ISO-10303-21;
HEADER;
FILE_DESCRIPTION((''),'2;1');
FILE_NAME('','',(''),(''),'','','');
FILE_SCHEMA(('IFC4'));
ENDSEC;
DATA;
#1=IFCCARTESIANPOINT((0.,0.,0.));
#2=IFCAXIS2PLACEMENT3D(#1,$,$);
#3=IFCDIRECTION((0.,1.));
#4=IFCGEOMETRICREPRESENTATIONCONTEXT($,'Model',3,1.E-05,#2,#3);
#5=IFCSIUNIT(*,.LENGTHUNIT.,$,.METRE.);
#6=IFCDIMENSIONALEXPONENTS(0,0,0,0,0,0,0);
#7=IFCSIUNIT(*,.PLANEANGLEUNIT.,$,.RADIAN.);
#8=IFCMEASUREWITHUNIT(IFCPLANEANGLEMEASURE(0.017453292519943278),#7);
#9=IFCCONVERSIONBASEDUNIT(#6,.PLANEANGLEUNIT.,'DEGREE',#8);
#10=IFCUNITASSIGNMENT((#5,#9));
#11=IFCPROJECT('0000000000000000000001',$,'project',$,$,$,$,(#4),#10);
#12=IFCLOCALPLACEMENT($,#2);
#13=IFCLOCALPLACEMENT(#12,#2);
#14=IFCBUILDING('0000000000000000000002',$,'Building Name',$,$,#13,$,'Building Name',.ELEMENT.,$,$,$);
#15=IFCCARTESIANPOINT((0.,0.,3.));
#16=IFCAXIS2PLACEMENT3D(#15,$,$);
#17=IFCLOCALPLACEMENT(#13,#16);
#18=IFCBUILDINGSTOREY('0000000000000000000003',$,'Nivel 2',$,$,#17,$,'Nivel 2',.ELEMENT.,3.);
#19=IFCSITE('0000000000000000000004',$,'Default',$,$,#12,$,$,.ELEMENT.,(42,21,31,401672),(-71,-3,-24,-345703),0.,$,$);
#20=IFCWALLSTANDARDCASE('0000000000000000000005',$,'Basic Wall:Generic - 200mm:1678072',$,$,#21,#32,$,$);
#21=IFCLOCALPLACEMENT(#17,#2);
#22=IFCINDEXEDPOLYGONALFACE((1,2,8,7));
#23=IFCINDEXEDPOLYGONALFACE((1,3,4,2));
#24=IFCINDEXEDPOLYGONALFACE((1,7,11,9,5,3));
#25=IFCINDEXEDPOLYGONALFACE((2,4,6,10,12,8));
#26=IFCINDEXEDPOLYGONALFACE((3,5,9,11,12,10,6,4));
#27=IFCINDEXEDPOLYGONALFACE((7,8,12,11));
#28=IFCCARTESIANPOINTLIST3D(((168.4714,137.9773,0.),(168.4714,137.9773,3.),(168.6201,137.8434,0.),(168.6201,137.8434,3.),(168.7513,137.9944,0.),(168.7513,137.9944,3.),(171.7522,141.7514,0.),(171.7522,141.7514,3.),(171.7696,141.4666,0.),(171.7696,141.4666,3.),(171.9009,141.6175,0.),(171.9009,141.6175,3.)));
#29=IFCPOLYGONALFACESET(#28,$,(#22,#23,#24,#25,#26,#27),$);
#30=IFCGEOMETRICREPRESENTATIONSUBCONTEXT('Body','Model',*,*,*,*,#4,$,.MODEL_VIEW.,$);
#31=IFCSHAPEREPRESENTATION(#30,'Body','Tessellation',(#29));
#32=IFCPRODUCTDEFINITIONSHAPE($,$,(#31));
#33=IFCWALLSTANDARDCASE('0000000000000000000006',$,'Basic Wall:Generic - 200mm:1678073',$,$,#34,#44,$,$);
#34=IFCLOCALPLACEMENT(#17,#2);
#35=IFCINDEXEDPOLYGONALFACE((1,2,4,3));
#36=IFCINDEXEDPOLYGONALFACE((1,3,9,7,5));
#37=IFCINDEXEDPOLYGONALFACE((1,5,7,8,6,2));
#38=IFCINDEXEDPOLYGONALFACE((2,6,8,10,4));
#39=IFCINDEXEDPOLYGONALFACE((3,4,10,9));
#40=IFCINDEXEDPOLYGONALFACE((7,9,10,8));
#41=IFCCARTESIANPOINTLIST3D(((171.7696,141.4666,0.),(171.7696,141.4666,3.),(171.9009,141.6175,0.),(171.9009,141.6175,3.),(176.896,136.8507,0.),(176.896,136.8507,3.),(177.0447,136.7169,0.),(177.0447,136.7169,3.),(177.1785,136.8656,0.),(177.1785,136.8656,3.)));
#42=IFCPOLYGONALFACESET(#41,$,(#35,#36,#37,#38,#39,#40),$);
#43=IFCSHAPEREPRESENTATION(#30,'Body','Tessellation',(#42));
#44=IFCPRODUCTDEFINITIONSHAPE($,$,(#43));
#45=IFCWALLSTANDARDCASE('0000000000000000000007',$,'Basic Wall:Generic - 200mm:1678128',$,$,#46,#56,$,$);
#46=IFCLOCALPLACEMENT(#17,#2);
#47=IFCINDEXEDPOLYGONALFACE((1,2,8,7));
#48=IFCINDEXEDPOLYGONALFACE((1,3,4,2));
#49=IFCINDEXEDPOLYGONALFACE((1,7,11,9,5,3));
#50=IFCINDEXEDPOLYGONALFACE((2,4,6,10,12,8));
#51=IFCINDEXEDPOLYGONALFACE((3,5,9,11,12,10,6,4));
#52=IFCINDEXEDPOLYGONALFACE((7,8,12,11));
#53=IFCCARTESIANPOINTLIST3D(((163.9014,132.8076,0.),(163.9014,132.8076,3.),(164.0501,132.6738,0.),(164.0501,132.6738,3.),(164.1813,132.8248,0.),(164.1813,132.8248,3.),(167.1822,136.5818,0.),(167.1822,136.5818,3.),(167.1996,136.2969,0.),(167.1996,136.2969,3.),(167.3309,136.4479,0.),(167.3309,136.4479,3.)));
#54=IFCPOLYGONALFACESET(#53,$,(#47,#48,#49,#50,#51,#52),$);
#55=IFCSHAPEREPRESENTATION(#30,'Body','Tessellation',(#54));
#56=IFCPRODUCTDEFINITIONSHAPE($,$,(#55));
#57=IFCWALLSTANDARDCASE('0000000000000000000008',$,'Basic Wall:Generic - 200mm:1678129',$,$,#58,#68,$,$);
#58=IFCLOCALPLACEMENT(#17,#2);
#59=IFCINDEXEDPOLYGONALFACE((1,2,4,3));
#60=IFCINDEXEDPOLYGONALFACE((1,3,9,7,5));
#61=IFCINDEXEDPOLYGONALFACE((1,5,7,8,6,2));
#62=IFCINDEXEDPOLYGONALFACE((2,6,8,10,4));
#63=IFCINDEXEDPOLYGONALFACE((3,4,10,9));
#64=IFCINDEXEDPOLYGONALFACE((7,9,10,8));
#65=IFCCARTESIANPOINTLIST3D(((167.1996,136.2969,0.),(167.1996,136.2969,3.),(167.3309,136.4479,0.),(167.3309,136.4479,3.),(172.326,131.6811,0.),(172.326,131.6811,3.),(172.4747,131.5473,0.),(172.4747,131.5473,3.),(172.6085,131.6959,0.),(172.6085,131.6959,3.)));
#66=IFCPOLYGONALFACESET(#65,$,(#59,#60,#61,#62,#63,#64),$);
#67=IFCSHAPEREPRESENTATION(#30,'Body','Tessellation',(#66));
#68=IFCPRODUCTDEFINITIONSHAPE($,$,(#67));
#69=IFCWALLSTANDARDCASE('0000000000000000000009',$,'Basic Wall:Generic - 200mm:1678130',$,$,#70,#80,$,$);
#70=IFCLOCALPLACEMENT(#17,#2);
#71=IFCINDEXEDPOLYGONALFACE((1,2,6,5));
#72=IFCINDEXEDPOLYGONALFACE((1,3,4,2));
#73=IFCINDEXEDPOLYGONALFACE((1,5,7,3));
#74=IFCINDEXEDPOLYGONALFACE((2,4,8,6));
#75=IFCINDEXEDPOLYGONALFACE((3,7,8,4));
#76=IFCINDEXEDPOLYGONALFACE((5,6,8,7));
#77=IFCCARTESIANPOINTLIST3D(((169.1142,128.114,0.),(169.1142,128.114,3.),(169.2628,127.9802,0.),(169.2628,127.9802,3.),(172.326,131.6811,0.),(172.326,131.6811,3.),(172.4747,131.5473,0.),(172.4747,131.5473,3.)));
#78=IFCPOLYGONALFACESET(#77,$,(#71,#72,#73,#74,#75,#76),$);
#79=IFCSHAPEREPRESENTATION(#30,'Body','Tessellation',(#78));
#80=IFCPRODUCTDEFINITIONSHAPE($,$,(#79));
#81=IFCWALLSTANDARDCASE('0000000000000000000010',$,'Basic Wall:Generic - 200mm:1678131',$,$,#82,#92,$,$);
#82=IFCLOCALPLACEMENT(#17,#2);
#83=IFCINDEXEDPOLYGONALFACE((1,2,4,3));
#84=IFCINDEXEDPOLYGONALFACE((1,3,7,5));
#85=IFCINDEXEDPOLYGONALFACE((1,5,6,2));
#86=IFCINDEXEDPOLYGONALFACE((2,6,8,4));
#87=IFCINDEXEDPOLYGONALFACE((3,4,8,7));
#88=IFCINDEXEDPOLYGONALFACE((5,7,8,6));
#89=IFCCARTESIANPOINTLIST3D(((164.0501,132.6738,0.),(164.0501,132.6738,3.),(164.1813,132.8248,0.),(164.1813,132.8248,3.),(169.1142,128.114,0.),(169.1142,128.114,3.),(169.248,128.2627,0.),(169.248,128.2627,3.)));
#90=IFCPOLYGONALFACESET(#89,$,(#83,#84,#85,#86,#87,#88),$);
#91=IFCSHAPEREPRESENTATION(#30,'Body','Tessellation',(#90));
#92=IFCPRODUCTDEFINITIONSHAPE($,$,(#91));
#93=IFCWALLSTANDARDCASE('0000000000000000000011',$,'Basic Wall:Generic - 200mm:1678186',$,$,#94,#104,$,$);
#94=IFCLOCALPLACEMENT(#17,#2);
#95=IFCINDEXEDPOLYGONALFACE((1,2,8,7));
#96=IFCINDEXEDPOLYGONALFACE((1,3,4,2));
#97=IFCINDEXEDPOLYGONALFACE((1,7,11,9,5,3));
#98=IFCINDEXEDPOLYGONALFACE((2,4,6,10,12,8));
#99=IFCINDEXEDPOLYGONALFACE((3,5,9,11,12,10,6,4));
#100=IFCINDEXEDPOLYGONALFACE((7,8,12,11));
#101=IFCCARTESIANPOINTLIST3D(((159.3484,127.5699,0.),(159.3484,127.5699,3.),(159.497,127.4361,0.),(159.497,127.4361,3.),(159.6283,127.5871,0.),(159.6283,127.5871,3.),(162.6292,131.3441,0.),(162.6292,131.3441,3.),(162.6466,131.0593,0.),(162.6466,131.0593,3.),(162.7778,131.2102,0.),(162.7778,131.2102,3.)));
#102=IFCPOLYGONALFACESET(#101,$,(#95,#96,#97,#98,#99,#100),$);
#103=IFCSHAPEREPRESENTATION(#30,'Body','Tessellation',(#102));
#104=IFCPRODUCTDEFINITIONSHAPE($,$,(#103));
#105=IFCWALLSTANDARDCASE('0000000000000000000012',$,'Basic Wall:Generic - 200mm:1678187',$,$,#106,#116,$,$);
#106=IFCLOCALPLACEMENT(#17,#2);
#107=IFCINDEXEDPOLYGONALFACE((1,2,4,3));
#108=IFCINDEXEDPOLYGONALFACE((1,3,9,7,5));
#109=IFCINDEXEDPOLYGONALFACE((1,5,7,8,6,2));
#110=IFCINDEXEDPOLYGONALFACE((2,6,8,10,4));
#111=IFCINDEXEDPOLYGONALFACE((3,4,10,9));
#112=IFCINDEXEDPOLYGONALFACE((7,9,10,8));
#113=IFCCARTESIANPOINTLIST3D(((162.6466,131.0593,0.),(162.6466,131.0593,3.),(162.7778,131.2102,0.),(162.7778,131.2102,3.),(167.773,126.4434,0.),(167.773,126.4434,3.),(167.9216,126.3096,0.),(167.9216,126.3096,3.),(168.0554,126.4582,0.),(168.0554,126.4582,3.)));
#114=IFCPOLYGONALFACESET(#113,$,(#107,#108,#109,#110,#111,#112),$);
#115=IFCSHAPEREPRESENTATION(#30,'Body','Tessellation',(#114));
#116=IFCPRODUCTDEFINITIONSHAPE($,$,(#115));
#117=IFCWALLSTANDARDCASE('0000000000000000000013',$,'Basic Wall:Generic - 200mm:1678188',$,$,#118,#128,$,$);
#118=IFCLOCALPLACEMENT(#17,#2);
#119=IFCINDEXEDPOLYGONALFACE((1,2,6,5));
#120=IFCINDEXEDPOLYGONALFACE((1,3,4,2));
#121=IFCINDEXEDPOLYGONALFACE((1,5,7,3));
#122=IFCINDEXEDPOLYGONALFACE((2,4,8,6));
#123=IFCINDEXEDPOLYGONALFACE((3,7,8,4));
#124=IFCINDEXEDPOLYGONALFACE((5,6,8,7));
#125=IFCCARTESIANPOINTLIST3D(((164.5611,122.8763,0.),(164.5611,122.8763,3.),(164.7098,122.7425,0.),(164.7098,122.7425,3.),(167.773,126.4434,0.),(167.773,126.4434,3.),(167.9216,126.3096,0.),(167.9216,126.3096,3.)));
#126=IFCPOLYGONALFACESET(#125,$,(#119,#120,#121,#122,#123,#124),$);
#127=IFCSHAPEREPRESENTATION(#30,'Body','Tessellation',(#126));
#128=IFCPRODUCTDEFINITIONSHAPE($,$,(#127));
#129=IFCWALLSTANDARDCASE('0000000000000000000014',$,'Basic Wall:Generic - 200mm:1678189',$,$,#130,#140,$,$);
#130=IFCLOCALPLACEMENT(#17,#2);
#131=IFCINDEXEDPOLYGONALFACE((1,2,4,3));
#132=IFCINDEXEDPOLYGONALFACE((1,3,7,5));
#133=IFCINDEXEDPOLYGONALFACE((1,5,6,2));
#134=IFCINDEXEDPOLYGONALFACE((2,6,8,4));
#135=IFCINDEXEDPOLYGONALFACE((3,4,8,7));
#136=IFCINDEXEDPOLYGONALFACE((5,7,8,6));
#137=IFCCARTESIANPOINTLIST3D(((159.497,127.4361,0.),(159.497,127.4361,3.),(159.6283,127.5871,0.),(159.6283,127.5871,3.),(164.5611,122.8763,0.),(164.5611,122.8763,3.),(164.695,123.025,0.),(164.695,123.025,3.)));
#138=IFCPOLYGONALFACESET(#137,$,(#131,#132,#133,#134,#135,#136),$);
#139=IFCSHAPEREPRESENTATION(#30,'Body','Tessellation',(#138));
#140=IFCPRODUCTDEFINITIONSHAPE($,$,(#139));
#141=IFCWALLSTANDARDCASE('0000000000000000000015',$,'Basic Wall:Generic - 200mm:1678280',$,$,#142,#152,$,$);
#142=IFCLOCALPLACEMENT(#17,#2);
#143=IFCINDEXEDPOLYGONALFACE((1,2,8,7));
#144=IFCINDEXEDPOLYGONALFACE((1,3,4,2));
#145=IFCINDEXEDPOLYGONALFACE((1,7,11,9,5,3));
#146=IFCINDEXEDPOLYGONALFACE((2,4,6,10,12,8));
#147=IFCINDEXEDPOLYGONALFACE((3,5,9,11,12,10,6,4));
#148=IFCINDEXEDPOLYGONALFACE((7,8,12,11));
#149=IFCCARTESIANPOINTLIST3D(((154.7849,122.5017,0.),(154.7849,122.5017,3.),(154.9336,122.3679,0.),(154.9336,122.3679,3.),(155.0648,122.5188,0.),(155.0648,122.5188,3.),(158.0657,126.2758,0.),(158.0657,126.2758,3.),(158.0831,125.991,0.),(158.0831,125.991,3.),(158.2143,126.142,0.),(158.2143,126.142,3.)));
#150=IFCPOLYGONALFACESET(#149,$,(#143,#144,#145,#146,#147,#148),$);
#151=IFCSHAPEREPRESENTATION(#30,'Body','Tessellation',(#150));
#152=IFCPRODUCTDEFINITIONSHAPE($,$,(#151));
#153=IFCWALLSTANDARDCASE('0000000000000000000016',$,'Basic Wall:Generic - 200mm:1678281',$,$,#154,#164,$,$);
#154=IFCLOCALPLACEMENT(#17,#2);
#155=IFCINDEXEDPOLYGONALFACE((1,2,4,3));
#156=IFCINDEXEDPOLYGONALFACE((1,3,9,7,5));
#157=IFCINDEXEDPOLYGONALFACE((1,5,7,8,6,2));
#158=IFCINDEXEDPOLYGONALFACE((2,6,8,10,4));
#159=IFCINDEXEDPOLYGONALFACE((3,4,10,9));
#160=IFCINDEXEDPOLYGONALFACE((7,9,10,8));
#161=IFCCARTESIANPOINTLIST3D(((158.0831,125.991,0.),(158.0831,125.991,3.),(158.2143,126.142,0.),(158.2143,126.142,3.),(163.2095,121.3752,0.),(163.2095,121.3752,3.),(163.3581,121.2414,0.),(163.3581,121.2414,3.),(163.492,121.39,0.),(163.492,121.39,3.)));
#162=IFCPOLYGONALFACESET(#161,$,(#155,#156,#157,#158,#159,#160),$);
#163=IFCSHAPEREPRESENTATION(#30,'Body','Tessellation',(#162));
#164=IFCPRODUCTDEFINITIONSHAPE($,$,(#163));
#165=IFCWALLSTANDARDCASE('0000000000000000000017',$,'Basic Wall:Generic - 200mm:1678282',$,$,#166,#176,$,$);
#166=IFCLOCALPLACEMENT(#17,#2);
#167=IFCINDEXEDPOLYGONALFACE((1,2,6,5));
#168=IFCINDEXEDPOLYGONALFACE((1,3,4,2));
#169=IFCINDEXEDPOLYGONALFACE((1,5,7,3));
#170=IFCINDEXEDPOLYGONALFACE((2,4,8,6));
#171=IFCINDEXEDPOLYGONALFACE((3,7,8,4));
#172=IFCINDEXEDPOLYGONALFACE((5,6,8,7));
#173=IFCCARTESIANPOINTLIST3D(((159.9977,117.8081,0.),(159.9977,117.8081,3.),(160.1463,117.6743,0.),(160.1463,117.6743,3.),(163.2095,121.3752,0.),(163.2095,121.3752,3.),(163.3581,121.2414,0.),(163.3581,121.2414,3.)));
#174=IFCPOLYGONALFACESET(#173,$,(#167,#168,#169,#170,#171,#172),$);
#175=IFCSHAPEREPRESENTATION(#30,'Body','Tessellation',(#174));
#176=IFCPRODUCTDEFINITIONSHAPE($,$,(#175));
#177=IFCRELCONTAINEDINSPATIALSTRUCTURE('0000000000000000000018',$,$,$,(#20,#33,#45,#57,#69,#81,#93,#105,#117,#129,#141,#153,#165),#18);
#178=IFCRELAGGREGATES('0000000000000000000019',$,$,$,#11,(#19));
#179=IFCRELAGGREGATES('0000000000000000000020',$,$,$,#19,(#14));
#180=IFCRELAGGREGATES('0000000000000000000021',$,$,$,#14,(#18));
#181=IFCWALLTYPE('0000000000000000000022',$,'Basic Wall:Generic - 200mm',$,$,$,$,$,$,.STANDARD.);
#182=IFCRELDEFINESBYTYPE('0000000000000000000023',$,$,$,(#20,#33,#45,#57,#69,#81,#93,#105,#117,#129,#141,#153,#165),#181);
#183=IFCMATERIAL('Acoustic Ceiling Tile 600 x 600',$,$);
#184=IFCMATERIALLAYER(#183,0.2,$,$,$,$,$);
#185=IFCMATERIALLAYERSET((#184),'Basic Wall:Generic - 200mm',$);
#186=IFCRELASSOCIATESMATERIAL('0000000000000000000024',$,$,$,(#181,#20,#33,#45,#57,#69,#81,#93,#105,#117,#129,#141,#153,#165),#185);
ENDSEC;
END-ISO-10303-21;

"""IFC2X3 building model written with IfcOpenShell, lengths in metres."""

from ifc_helpers import new_model, entity, si_unit, converted_unit, direction, frame, frame_2d, origin, place, context, subcontext, project, spatial, polyline, rectangle, outline, extrude, material, layer, layer_set, layer_usage, type_object, element, save


model = new_model("IFC2X3")

# Units and contexts
model_context = context("Model", 3, precision=1e-05, world=origin(), true_north=direction((0.0, 1.0)))
body_context = subcontext(model_context, "Body", "Model", "MODEL_VIEW")
ifc_project = project(units=[si_unit("LENGTHUNIT", "METRE"), converted_unit("PLANEANGLEUNIT", "DEGREE", entity("IfcPlaneAngleMeasure", 0.017453292519943278), si_unit("PLANEANGLEUNIT", "RADIAN"), dimensions=[0, 0, 0, 0, 0, 0, 0])], contexts=[model_context])

# Site, building, storey
site_placement = place(None, origin())
site = spatial("IfcSite", under=ifc_project, at=site_placement, Name="Default", CompositionType="ELEMENT", RefLatitude=(42, 21, 31, 401672), RefLongitude=(-71, -3, -24, -345703), RefElevation=0.0)
building_placement = place(site_placement, origin())
building = spatial("IfcBuilding", under=site, at=building_placement, Name="Building Name", LongName="Building Name", CompositionType="ELEMENT")
storey_placement = place(building_placement, frame((0.0, 0.0, 3.0)))
storey = spatial("IfcBuildingStorey", under=building, at=storey_placement, Name="Nivel 2", LongName="Nivel 2", CompositionType="ELEMENT", Elevation=3.0)

# Shared definitions
ifc_material_1 = material(Name="Acoustic Ceiling Tile 600 x 600")
ifc_layer = layer(ifc_material_1, 0.2)
ifc_layer_set = layer_set([ifc_layer], Name="Basic Wall:Generic - 200mm")
wall_type_1 = type_object("IfcWallType", Name="Basic Wall:Generic - 200mm", PredefinedType="STANDARD", material=ifc_layer_set)

# Walls
ifc_layer_usage_1 = layer_usage(ifc_layer_set, "AXIS2", "NEGATIVE", 0.1)
wall_1_placement = place(storey_placement, frame((168.5446, 137.909, 0.0), z_axis=(0.0, 0.0, 1.0), x_axis=(0.656059, 0.75471, 0.0)))
element("IfcWallStandardCase", 1, at=wall_1_placement, inside=storey, type_object=wall_type_1, material=ifc_layer_usage_1, Name="Basic Wall:Generic - 200mm:1678072", context=body_context, shape_type="SweptSolid", body=[
    extrude(outline(polyline([(5.0008, -0.1), (5.0043, 0.1), (0.0035, 0.1), (0.0, -0.1), (0.2, -0.1), (4.8007, -0.1), (5.0008, -0.1)])), origin(), (0.0, 0.0, 1.0), 3.0),
])
ifc_layer_usage_2 = layer_usage(ifc_layer_set, "AXIS2", "NEGATIVE", 0.1)
wall_2_placement = place(storey_placement, frame((171.834, 141.5432, 0.0), z_axis=(0.0, 0.0, 1.0), x_axis=(0.743145, -0.669131, 0.0)))
element("IfcWallStandardCase", 2, at=wall_2_placement, inside=storey, type_object=wall_type_1, material=ifc_layer_usage_2, Name="Basic Wall:Generic - 200mm:1678073", context=body_context, shape_type="SweptSolid", body=[
    extrude(outline(polyline([(7.1017, -0.1), (7.1017, 0.1), (0.0, 0.1), (0.0035, -0.1), (6.9017, -0.1), (7.1017, -0.1)])), origin(), (0.0, 0.0, 1.0), 3.0),
])
ifc_layer_usage_3 = layer_usage(ifc_layer_set, "AXIS2", "NEGATIVE", 0.1)
wall_3_placement = place(storey_placement, frame((163.9746, 132.7394, 0.0), z_axis=(0.0, 0.0, 1.0), x_axis=(0.656059, 0.75471, 0.0)))
element("IfcWallStandardCase", 3, at=wall_3_placement, inside=storey, type_object=wall_type_1, material=ifc_layer_usage_3, Name="Basic Wall:Generic - 200mm:1678128", context=body_context, shape_type="SweptSolid", body=[
    extrude(outline(polyline([(5.0008, -0.1), (5.0043, 0.1), (0.0035, 0.1), (0.0, -0.1), (0.2, -0.1), (4.8007, -0.1), (5.0008, -0.1)])), origin(), (0.0, 0.0, 1.0), 3.0),
])
ifc_layer_usage_4 = layer_usage(ifc_layer_set, "AXIS2", "NEGATIVE", 0.1)
wall_4_placement = place(storey_placement, frame((167.264, 136.3736, 0.0), z_axis=(0.0, 0.0, 1.0), x_axis=(0.743145, -0.669131, 0.0)))
element("IfcWallStandardCase", 4, at=wall_4_placement, inside=storey, type_object=wall_type_1, material=ifc_layer_usage_4, Name="Basic Wall:Generic - 200mm:1678129", context=body_context, shape_type="SweptSolid", body=[
    extrude(outline(polyline([(7.1017, -0.1), (7.1017, 0.1), (0.0, 0.1), (0.0035, -0.1), (6.9017, -0.1), (7.1017, -0.1)])), origin(), (0.0, 0.0, 1.0), 3.0),
])
ifc_layer_usage_5 = layer_usage(ifc_layer_set, "AXIS2", "NEGATIVE", 0.1)
wall_5_placement = place(storey_placement, frame((172.4003, 131.6142, 0.0), z_axis=(0.0, 0.0, 1.0), x_axis=(-0.669131, -0.743145, 0.0)))
element("IfcWallStandardCase", 5, at=wall_5_placement, inside=storey, type_object=wall_type_1, material=ifc_layer_usage_5, Name="Basic Wall:Generic - 200mm:1678130", context=body_context, shape_type="SweptSolid", body=[
    extrude(rectangle(XDim=4.8, YDim=0.2, at=frame_2d((2.4, 0.0), x_axis=(-1.0, 0.0))), origin(), (0.0, 0.0, 1.0), 3.0),
])
ifc_layer_usage_6 = layer_usage(ifc_layer_set, "AXIS2", "NEGATIVE", 0.1)
wall_6_placement = place(storey_placement, frame((169.1811, 128.1883, 0.0), z_axis=(0.0, 0.0, 1.0), x_axis=(-0.743145, 0.669131, 0.0)))
element("IfcWallStandardCase", 6, at=wall_6_placement, inside=storey, type_object=wall_type_1, material=ifc_layer_usage_6, Name="Basic Wall:Generic - 200mm:1678131", context=body_context, shape_type="SweptSolid", body=[
    extrude(outline(polyline([(6.8179, -0.1), (6.8145, 0.1), (0.0, 0.1), (0.0, -0.1), (6.8179, -0.1)])), origin(), (0.0, 0.0, 1.0), 3.0),
])
ifc_layer_usage_7 = layer_usage(ifc_layer_set, "AXIS2", "NEGATIVE", 0.1)
wall_7_placement = place(storey_placement, frame((159.4216, 127.5017, 0.0), z_axis=(0.0, 0.0, 1.0), x_axis=(0.656059, 0.75471, 0.0)))
element("IfcWallStandardCase", 7, at=wall_7_placement, inside=storey, type_object=wall_type_1, material=ifc_layer_usage_7, Name="Basic Wall:Generic - 200mm:1678186", context=body_context, shape_type="SweptSolid", body=[
    extrude(outline(polyline([(5.0008, -0.1), (5.0043, 0.1), (0.0035, 0.1), (0.0, -0.1), (0.2, -0.1), (4.8007, -0.1), (5.0008, -0.1)])), origin(), (0.0, 0.0, 1.0), 3.0),
])
ifc_layer_usage_8 = layer_usage(ifc_layer_set, "AXIS2", "NEGATIVE", 0.1)
wall_8_placement = place(storey_placement, frame((162.7109, 131.1359, 0.0), z_axis=(0.0, 0.0, 1.0), x_axis=(0.743145, -0.669131, 0.0)))
element("IfcWallStandardCase", 8, at=wall_8_placement, inside=storey, type_object=wall_type_1, material=ifc_layer_usage_8, Name="Basic Wall:Generic - 200mm:1678187", context=body_context, shape_type="SweptSolid", body=[
    extrude(outline(polyline([(7.1017, -0.1), (7.1017, 0.1), (0.0, 0.1), (0.0035, -0.1), (6.9017, -0.1), (7.1017, -0.1)])), origin(), (0.0, 0.0, 1.0), 3.0),
])
ifc_layer_usage_9 = layer_usage(ifc_layer_set, "AXIS2", "NEGATIVE", 0.1)
wall_9_placement = place(storey_placement, frame((167.8473, 126.3765, 0.0), z_axis=(0.0, 0.0, 1.0), x_axis=(-0.669131, -0.743145, 0.0)))
element("IfcWallStandardCase", 9, at=wall_9_placement, inside=storey, type_object=wall_type_1, material=ifc_layer_usage_9, Name="Basic Wall:Generic - 200mm:1678188", context=body_context, shape_type="SweptSolid", body=[
    extrude(rectangle(XDim=4.8, YDim=0.2, at=frame_2d((2.4, 0.0), x_axis=(-1.0, 0.0))), origin(), (0.0, 0.0, 1.0), 3.0),
])
ifc_layer_usage_10 = layer_usage(ifc_layer_set, "AXIS2", "NEGATIVE", 0.1)
wall_10_placement = place(storey_placement, frame((164.6281, 122.9507, 0.0), z_axis=(0.0, 0.0, 1.0), x_axis=(-0.743145, 0.669131, 0.0)))
element("IfcWallStandardCase", 10, at=wall_10_placement, inside=storey, type_object=wall_type_1, material=ifc_layer_usage_10, Name="Basic Wall:Generic - 200mm:1678189", context=body_context, shape_type="SweptSolid", body=[
    extrude(outline(polyline([(6.8179, -0.1), (6.8145, 0.1), (0.0, 0.1), (0.0, -0.1), (6.8179, -0.1)])), origin(), (0.0, 0.0, 1.0), 3.0),
])
ifc_layer_usage_11 = layer_usage(ifc_layer_set, "AXIS2", "NEGATIVE", 0.1)
wall_11_placement = place(storey_placement, frame((154.8581, 122.4335, 0.0), z_axis=(0.0, 0.0, 1.0), x_axis=(0.656059, 0.75471, 0.0)))
element("IfcWallStandardCase", 11, at=wall_11_placement, inside=storey, type_object=wall_type_1, material=ifc_layer_usage_11, Name="Basic Wall:Generic - 200mm:1678280", context=body_context, shape_type="SweptSolid", body=[
    extrude(outline(polyline([(5.0008, -0.1), (5.0043, 0.1), (0.0035, 0.1), (0.0, -0.1), (0.2, -0.1), (4.8007, -0.1), (5.0008, -0.1)])), origin(), (0.0, 0.0, 1.0), 3.0),
])
ifc_layer_usage_12 = layer_usage(ifc_layer_set, "AXIS2", "NEGATIVE", 0.1)
wall_12_placement = place(storey_placement, frame((158.1474, 126.0677, 0.0), z_axis=(0.0, 0.0, 1.0), x_axis=(0.743145, -0.669131, 0.0)))
element("IfcWallStandardCase", 12, at=wall_12_placement, inside=storey, type_object=wall_type_1, material=ifc_layer_usage_12, Name="Basic Wall:Generic - 200mm:1678281", context=body_context, shape_type="SweptSolid", body=[
    extrude(outline(polyline([(7.1017, -0.1), (7.1017, 0.1), (0.0, 0.1), (0.0035, -0.1), (6.9017, -0.1), (7.1017, -0.1)])), origin(), (0.0, 0.0, 1.0), 3.0),
])
ifc_layer_usage_13 = layer_usage(ifc_layer_set, "AXIS2", "NEGATIVE", 0.1)
wall_13_placement = place(storey_placement, frame((163.2838, 121.3083, 0.0), z_axis=(0.0, 0.0, 1.0), x_axis=(-0.669131, -0.743145, 0.0)))
element("IfcWallStandardCase", 13, at=wall_13_placement, inside=storey, type_object=wall_type_1, material=ifc_layer_usage_13, Name="Basic Wall:Generic - 200mm:1678282", context=body_context, shape_type="SweptSolid", body=[
    extrude(rectangle(XDim=4.8, YDim=0.2, at=frame_2d((2.4, 0.0), x_axis=(-1.0, 0.0))), origin(), (0.0, 0.0, 1.0), 3.0),
])

save(model, "model.ifc")
